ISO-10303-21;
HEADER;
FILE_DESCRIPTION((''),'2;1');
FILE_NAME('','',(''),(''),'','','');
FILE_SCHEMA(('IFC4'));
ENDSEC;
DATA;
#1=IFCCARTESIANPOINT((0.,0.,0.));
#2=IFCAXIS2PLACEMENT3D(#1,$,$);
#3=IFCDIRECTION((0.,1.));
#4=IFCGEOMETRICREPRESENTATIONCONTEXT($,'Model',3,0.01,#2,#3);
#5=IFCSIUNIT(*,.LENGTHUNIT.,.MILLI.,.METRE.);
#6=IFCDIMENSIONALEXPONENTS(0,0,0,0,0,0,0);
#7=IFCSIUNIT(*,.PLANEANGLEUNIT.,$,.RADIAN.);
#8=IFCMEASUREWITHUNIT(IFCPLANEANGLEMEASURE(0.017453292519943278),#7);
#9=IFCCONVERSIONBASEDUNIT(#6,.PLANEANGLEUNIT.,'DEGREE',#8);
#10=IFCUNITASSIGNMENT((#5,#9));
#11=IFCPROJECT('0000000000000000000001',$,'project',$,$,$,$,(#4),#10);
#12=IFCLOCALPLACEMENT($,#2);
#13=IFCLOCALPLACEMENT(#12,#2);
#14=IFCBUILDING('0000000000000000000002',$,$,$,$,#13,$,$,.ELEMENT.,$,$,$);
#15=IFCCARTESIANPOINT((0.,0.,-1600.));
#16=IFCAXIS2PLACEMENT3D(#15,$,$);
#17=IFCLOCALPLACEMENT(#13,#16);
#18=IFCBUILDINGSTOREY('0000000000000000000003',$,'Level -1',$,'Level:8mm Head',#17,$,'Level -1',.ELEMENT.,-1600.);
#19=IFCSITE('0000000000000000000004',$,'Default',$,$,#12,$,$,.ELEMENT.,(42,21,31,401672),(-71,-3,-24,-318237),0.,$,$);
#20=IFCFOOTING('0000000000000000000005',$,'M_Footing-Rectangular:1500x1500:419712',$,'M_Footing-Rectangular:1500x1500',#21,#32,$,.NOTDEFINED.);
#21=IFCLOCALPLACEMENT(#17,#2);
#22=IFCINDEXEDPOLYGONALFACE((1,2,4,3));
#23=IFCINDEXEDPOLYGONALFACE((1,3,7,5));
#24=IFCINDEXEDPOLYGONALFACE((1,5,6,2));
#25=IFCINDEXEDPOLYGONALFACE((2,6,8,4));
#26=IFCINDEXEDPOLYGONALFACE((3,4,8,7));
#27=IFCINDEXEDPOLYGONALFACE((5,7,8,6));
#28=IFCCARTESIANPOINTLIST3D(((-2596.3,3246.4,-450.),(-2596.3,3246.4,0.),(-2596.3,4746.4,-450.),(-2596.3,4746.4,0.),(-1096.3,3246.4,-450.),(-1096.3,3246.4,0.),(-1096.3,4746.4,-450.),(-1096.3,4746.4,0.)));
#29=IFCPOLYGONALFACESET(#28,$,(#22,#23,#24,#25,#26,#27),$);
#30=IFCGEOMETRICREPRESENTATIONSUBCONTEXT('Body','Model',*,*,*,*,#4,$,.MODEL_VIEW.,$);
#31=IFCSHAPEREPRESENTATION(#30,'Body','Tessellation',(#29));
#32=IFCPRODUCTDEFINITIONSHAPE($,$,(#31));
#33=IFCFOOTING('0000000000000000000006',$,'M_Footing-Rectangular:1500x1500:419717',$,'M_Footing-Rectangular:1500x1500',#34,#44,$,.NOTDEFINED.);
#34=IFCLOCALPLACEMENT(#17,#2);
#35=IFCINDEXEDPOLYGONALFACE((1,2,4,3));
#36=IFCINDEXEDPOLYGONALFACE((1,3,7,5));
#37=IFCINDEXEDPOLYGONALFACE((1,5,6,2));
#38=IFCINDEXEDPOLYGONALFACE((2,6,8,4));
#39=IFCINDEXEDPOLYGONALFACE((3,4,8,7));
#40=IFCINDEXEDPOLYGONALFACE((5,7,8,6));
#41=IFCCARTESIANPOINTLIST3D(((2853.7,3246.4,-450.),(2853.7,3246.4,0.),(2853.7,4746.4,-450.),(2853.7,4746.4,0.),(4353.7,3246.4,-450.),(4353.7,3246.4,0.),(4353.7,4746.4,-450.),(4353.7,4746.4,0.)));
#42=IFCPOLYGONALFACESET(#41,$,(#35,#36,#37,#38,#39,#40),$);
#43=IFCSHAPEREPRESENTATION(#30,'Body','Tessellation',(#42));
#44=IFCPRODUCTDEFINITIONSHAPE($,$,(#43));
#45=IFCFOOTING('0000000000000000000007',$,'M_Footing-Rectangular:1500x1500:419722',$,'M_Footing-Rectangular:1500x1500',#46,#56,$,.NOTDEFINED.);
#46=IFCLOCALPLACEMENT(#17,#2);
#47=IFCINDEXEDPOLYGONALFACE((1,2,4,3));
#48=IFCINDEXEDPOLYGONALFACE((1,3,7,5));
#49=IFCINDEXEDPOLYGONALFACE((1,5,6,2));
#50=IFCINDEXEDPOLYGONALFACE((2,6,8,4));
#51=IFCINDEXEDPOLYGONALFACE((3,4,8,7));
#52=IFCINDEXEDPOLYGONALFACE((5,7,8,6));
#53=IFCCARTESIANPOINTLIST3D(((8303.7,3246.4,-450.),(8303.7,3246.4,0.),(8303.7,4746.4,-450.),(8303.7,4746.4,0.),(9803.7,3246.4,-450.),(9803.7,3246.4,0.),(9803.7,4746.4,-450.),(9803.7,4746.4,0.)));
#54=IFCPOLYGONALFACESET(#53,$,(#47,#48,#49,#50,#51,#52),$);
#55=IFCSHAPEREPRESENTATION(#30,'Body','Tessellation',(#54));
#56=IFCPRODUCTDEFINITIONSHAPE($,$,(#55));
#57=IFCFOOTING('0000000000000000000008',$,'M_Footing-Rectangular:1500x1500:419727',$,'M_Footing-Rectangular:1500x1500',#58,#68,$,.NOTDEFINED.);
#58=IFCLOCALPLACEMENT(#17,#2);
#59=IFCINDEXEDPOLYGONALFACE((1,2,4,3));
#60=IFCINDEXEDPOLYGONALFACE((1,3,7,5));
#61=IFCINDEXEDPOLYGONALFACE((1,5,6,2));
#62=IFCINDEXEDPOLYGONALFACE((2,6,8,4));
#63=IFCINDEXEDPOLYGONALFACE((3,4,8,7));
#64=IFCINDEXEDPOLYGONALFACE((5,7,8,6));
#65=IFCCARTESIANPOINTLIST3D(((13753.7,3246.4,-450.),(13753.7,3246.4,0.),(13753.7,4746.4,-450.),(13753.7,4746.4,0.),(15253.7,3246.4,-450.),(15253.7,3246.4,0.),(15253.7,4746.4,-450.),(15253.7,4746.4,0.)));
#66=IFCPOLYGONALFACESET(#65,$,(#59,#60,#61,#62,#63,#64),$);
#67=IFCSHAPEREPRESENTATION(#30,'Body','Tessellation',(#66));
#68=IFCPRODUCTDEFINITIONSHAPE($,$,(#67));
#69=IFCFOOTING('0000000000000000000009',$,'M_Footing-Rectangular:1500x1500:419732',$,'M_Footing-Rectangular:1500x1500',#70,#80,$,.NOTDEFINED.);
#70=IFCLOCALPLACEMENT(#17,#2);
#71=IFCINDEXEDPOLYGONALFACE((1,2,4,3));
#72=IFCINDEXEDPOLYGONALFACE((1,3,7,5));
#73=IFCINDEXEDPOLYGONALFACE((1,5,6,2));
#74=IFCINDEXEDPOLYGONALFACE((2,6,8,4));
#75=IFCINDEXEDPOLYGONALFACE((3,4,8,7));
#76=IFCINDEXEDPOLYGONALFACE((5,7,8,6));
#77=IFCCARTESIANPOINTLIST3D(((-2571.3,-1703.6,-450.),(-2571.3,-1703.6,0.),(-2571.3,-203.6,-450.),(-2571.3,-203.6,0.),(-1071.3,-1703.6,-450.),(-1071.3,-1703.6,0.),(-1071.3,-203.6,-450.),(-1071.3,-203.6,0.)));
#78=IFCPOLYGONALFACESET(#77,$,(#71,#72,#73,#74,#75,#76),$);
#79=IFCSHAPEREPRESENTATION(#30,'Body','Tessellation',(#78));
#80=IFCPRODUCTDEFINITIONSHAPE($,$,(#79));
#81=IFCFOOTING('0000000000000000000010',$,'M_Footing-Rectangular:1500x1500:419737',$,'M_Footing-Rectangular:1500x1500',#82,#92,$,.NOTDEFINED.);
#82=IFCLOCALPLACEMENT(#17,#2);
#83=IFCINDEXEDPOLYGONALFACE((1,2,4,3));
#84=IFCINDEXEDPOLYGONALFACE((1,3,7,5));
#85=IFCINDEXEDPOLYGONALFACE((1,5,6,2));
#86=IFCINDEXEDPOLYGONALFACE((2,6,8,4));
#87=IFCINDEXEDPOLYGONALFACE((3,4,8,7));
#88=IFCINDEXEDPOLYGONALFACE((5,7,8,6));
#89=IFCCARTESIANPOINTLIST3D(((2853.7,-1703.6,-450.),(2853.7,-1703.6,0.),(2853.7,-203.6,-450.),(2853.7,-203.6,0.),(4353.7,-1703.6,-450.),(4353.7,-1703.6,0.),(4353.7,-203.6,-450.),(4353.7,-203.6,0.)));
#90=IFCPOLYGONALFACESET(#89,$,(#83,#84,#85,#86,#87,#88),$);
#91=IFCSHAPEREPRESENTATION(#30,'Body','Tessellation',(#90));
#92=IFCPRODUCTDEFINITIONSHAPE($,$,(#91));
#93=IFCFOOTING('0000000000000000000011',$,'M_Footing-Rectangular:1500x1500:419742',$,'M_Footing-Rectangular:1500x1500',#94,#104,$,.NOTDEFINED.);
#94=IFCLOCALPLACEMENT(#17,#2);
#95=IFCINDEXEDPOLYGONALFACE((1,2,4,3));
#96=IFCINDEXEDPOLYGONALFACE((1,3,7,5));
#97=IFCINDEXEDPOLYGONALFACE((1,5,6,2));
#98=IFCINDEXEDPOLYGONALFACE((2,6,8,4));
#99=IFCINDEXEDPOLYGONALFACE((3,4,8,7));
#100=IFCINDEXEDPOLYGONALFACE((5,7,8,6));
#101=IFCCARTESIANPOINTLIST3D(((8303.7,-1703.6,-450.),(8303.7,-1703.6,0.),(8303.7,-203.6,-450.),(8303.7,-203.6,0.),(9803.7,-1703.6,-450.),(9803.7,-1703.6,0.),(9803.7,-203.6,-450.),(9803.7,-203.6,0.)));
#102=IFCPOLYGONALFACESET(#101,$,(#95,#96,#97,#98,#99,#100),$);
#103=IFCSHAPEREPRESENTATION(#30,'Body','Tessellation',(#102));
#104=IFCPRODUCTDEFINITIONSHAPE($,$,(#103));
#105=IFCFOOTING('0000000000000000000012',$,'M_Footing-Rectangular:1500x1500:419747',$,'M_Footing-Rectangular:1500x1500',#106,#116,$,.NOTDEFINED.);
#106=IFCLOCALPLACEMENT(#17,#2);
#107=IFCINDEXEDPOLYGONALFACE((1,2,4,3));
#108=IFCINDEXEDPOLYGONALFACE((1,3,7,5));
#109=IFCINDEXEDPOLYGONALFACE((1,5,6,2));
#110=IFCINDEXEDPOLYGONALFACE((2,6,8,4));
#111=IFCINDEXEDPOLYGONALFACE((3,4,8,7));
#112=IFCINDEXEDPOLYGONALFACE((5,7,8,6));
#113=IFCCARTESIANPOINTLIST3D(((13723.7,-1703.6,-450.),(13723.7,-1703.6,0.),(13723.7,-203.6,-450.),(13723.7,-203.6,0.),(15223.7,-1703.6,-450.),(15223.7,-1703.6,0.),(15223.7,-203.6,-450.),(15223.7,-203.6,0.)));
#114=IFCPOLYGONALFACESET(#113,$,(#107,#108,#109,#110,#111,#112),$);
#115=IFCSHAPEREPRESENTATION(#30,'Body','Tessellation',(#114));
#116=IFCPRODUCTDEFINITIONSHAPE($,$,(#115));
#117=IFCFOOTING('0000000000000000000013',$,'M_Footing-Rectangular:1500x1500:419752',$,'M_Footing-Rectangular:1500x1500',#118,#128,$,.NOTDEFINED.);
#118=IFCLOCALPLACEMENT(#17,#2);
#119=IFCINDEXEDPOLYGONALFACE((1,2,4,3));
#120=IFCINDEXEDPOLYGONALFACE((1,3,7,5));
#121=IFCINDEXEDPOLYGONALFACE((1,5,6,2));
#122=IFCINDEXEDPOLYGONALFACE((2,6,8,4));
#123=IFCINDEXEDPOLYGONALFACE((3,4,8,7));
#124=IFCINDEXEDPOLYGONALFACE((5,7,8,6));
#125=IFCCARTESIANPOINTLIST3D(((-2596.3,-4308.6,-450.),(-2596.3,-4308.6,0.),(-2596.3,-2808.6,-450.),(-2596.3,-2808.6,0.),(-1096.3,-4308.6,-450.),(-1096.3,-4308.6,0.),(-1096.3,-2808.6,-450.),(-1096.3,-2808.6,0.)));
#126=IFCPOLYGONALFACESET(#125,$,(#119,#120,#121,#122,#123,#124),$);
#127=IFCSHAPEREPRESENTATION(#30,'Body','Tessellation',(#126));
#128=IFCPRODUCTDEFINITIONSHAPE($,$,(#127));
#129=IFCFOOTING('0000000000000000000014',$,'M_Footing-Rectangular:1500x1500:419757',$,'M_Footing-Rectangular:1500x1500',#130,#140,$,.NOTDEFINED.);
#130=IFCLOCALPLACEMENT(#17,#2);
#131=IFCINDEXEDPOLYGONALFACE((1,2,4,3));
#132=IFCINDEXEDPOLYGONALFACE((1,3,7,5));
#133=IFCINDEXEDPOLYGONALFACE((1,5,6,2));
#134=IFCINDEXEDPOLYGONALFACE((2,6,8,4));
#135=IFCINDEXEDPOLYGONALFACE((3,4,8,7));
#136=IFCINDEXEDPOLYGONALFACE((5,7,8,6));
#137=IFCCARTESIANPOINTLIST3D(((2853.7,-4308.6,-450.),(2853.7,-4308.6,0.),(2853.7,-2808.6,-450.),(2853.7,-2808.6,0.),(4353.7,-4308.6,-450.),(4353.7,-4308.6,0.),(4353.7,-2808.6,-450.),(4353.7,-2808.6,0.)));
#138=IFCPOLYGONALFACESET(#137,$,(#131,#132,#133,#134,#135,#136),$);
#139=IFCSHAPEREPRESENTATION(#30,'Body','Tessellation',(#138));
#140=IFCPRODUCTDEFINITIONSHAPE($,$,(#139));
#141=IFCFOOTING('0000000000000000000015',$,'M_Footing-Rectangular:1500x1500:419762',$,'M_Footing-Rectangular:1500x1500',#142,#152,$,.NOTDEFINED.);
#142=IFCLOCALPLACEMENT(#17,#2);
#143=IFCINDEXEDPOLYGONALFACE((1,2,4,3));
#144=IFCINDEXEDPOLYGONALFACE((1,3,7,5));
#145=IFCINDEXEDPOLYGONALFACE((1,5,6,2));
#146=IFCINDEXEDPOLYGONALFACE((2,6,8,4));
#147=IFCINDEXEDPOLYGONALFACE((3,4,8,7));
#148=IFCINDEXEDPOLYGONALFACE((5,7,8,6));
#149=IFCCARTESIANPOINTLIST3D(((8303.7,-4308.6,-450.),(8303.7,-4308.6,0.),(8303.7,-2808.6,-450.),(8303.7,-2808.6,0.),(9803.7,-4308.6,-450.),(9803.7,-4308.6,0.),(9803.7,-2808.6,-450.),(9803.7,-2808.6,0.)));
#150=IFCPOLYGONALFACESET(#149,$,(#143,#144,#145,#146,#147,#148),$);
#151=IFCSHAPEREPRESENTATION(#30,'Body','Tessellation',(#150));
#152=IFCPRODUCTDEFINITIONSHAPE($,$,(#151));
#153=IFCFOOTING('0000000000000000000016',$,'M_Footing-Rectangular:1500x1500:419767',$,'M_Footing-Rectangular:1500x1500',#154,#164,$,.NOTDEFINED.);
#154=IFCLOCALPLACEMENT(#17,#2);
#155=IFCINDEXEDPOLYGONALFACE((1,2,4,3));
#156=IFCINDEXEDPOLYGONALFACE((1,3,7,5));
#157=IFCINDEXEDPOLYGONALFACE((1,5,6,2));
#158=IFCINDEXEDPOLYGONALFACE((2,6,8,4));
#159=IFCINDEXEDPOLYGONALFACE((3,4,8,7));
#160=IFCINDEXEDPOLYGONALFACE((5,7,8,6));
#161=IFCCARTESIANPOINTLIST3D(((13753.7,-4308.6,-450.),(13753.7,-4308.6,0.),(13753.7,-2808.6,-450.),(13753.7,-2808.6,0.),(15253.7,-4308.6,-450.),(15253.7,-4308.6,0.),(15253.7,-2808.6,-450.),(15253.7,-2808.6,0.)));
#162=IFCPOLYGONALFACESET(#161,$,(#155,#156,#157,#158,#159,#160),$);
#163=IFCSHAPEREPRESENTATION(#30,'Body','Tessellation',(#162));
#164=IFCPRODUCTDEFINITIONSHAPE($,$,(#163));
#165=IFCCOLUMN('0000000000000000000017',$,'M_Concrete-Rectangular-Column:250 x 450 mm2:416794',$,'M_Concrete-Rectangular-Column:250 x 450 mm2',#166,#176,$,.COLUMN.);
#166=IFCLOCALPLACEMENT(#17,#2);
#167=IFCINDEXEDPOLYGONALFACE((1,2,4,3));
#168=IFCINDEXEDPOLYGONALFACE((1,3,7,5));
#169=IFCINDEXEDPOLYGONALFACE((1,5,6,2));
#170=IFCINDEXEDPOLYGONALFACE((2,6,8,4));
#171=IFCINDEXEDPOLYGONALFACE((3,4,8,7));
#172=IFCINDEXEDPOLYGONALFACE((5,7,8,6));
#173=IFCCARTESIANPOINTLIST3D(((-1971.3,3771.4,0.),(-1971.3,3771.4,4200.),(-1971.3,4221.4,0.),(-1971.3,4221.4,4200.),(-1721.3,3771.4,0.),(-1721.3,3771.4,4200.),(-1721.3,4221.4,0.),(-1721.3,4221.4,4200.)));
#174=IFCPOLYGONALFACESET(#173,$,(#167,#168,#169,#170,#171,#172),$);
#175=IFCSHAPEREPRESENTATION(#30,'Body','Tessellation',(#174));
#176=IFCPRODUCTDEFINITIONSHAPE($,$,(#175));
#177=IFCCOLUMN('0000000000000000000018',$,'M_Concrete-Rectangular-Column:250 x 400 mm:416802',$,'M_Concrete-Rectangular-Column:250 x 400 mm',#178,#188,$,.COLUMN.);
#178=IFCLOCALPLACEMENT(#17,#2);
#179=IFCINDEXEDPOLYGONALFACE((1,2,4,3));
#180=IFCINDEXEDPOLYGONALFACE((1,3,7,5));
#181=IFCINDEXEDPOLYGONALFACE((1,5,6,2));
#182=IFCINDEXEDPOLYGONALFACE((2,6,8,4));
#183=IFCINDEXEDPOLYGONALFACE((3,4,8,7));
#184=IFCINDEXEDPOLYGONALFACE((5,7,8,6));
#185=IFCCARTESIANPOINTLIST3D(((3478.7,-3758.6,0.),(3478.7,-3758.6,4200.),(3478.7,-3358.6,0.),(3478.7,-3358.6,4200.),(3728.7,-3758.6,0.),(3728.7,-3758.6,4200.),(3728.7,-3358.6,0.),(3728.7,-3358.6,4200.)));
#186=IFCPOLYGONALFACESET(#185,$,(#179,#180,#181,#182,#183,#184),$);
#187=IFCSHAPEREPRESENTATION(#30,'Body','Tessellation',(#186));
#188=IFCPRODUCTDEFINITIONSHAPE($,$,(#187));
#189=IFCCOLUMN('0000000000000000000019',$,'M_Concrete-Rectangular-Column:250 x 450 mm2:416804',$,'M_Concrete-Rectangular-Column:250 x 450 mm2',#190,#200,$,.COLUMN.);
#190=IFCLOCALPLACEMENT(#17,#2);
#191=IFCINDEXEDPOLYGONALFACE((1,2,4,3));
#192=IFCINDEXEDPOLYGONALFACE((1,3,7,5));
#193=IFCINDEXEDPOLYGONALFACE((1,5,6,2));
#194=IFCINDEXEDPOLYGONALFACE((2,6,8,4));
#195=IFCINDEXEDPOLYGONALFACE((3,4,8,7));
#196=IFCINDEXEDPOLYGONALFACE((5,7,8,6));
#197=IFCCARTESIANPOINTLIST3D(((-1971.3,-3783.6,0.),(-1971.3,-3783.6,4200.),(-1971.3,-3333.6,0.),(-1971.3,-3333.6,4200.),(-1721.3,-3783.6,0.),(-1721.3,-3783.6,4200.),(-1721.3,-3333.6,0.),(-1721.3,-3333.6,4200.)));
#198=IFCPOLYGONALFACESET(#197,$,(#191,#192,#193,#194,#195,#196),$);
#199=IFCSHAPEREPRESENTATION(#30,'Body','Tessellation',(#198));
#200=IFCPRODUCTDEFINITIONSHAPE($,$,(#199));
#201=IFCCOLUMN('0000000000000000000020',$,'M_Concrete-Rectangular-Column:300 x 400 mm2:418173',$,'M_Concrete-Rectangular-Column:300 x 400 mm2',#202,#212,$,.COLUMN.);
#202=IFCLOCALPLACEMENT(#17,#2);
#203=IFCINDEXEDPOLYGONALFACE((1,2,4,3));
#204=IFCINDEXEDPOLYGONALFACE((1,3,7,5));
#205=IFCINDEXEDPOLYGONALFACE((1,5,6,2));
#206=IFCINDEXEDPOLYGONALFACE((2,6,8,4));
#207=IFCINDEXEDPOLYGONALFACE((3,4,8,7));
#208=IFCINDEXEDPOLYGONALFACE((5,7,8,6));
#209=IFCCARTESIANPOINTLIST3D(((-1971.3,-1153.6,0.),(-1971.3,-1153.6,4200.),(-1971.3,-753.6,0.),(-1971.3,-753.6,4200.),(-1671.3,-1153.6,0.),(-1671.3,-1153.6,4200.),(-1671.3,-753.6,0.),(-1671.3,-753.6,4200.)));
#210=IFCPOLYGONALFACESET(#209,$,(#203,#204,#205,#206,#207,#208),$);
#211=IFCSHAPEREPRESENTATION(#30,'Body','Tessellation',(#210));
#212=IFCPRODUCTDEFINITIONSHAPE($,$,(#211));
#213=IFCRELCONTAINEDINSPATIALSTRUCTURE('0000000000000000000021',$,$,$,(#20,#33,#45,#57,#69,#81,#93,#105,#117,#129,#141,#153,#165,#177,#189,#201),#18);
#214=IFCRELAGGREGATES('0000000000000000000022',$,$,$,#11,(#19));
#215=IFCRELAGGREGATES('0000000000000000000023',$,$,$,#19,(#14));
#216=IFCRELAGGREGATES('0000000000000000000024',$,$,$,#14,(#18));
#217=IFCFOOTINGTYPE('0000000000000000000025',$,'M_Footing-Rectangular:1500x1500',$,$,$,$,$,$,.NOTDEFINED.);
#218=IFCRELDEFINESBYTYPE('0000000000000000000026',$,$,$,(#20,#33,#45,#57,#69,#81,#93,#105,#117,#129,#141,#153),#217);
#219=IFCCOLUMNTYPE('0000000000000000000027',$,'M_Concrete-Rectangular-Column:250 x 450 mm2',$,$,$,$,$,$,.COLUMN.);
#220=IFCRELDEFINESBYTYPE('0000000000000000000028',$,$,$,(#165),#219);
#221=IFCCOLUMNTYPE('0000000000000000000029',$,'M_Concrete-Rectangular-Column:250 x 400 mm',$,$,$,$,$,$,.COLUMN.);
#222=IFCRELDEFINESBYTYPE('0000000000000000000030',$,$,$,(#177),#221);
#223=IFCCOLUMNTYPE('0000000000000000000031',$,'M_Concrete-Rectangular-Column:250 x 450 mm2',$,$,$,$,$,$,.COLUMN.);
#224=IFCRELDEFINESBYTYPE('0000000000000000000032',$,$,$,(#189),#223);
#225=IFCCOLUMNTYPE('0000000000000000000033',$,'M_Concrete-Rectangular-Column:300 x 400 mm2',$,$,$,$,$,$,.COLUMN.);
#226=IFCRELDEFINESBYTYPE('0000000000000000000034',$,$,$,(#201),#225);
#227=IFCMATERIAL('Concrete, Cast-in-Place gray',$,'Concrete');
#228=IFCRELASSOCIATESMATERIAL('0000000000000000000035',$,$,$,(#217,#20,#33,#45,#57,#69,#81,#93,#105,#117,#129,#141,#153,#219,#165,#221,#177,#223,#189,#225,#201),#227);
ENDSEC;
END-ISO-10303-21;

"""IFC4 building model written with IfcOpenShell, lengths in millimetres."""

from ifc_helpers import new_model, entity, si_unit, converted_unit, direction, frame, origin, place, context, subcontext, project, spatial, indexed_curve, outline, extrude, source, transform, mapped, material, type_object, type_shapes, element, save


model = new_model("IFC4")

# Units and contexts
model_context = context("Model", 3, precision=0.01, world=origin(), true_north=direction((0.0, 1.0)))
body_context = subcontext(model_context, "Body", "Model", "MODEL_VIEW")
ifc_project = project(units=[si_unit("LENGTHUNIT", "METRE", prefix="MILLI"), converted_unit("PLANEANGLEUNIT", "DEGREE", entity("IfcPlaneAngleMeasure", 0.017453292519943278), si_unit("PLANEANGLEUNIT", "RADIAN"), dimensions=[0, 0, 0, 0, 0, 0, 0])], contexts=[model_context])

# Site, building, storey
site_placement = place(None, origin())
site = spatial("IfcSite", under=ifc_project, at=site_placement, Name="Default", CompositionType="ELEMENT", RefLatitude=(42, 21, 31, 401672), RefLongitude=(-71, -3, -24, -318237), RefElevation=0.0)
building_placement = place(site_placement, origin())
building = spatial("IfcBuilding", under=site, at=building_placement, CompositionType="ELEMENT")
storey_placement = place(building_placement, frame((0.0, 0.0, -1600.0)))
storey = spatial("IfcBuildingStorey", under=building, at=storey_placement, Name="Level -1", ObjectType="Level:8mm Head", LongName="Level -1", CompositionType="ELEMENT", Elevation=-1600.0)

# Footings
ifc_material = material(Name="Concrete, Cast-in-Place gray", Category="Concrete")
footing_type = type_object("IfcFootingType", Name="M_Footing-Rectangular:1500x1500", PredefinedType="NOTDEFINED", material=ifc_material)
shared_shape_1 = source(origin(), body_context, "Body", "SweptSolid", [
    extrude(outline(indexed_curve([(-750.0, -750.0), (750.0, -750.0), (750.0, 750.0), (-750.0, 750.0), (-750.0, -750.0)], self_intersect=False)), frame((0.0, 0.0, -450.0), z_axis=(0.0, 0.0, 1.0), x_axis=(-1.0, 0.0, 0.0)), (0.0, 0.0, 1.0), 450.0),
])
type_shapes(footing_type, [shared_shape_1])
for number, where, name in (
    (1, (-1846.3, 3996.4, 0.0), "M_Footing-Rectangular:1500x1500:419712"),
    (2, (3603.7, 3996.4, 0.0), "M_Footing-Rectangular:1500x1500:419717"),
    (3, (9053.7, 3996.4, 0.0), "M_Footing-Rectangular:1500x1500:419722"),
    (4, (14503.7, 3996.4, 0.0), "M_Footing-Rectangular:1500x1500:419727"),
    (5, (-1821.3, -953.6, 0.0), "M_Footing-Rectangular:1500x1500:419732"),
    (6, (3603.7, -953.6, 0.0), "M_Footing-Rectangular:1500x1500:419737"),
    (7, (9053.7, -953.6, 0.0), "M_Footing-Rectangular:1500x1500:419742"),
    (8, (14473.7, -953.6, 0.0), "M_Footing-Rectangular:1500x1500:419747"),
    (9, (-1846.3, -3558.6, 0.0), "M_Footing-Rectangular:1500x1500:419752"),
    (10, (3603.7, -3558.6, 0.0), "M_Footing-Rectangular:1500x1500:419757"),
    (11, (9053.7, -3558.6, 0.0), "M_Footing-Rectangular:1500x1500:419762"),
    (12, (14503.7, -3558.6, 0.0), "M_Footing-Rectangular:1500x1500:419767"),
):
    element("IfcFooting", number, at=place(storey_placement, frame(where)), inside=storey, type_object=footing_type, material=ifc_material, Name=name, ObjectType="M_Footing-Rectangular:1500x1500", PredefinedType="NOTDEFINED", context=body_context, shape_type="MappedRepresentation", body=[
        mapped(shared_shape_1, transform((0.0, 0.0, 0.0), scale=1.0)),
    ])

# Columns
column_type_1 = type_object("IfcColumnType", Name="M_Concrete-Rectangular-Column:250 x 450 mm2", PredefinedType="COLUMN", material=ifc_material)
shared_shape_2 = source(origin(), body_context, "Body", "SweptSolid", [
    extrude(outline(indexed_curve([(-2100.0, -225.0), (2100.0, -225.0), (2100.0, 225.0), (-2100.0, 225.0), (-2100.0, -225.0)], self_intersect=False)), frame((-1971.3, 3996.4, 500.0), z_axis=(1.0, 0.0, 0.0), x_axis=(0.0, 0.0, 1.0)), (0.0, 0.0, 1.0), 250.0),
])
type_shapes(column_type_1, [shared_shape_2])
column_1_placement = place(storey_placement, frame((0.0, 0.0, 1600.0)))
element("IfcColumn", 13, at=column_1_placement, inside=storey, type_object=column_type_1, material=ifc_material, Name="M_Concrete-Rectangular-Column:250 x 450 mm2:416794", ObjectType="M_Concrete-Rectangular-Column:250 x 450 mm2", PredefinedType="COLUMN", context=body_context, shape_type="MappedRepresentation", body=[
    mapped(shared_shape_2, transform((0.0, 0.0, 0.0), scale=1.0)),
])
column_type_2 = type_object("IfcColumnType", Name="M_Concrete-Rectangular-Column:250 x 400 mm", PredefinedType="COLUMN", material=ifc_material)
shared_shape_3 = source(origin(), body_context, "Body", "SweptSolid", [
    extrude(outline(indexed_curve([(-2100.0, -200.0), (2100.0, -200.0), (2100.0, 200.0), (-2100.0, 200.0), (-2100.0, -200.0)], self_intersect=False)), frame((3478.7, -3558.6, 500.0), z_axis=(1.0, 0.0, 0.0), x_axis=(0.0, 0.0, 1.0)), (0.0, 0.0, 1.0), 250.0),
])
type_shapes(column_type_2, [shared_shape_3])
column_2_placement = place(storey_placement, frame((0.0, 0.0, 1600.0)))
element("IfcColumn", 14, at=column_2_placement, inside=storey, type_object=column_type_2, material=ifc_material, Name="M_Concrete-Rectangular-Column:250 x 400 mm:416802", ObjectType="M_Concrete-Rectangular-Column:250 x 400 mm", PredefinedType="COLUMN", context=body_context, shape_type="MappedRepresentation", body=[
    mapped(shared_shape_3, transform((0.0, 0.0, 0.0), scale=1.0)),
])
column_type_3 = type_object("IfcColumnType", Name="M_Concrete-Rectangular-Column:250 x 450 mm2", PredefinedType="COLUMN", material=ifc_material)
shared_shape_4 = source(origin(), body_context, "Body", "SweptSolid", [
    extrude(outline(indexed_curve([(-2100.0, -225.0), (2100.0, -225.0), (2100.0, 225.0), (-2100.0, 225.0), (-2100.0, -225.0)], self_intersect=False)), frame((-1971.3, -3558.6, 500.0), z_axis=(1.0, 0.0, 0.0), x_axis=(0.0, 0.0, 1.0)), (0.0, 0.0, 1.0), 250.0),
])
type_shapes(column_type_3, [shared_shape_4])
column_3_placement = place(storey_placement, frame((0.0, 0.0, 1600.0)))
element("IfcColumn", 15, at=column_3_placement, inside=storey, type_object=column_type_3, material=ifc_material, Name="M_Concrete-Rectangular-Column:250 x 450 mm2:416804", ObjectType="M_Concrete-Rectangular-Column:250 x 450 mm2", PredefinedType="COLUMN", context=body_context, shape_type="MappedRepresentation", body=[
    mapped(shared_shape_4, transform((0.0, 0.0, 0.0), scale=1.0)),
])
column_type_4 = type_object("IfcColumnType", Name="M_Concrete-Rectangular-Column:300 x 400 mm2", PredefinedType="COLUMN", material=ifc_material)
shared_shape_5 = source(origin(), body_context, "Body", "SweptSolid", [
    extrude(outline(indexed_curve([(-2100.0, -200.0), (2100.0, -200.0), (2100.0, 200.0), (-2100.0, 200.0), (-2100.0, -200.0)], self_intersect=False)), frame((-1971.3, -953.6, 500.0), z_axis=(1.0, 0.0, 0.0), x_axis=(0.0, 0.0, 1.0)), (0.0, 0.0, 1.0), 300.0),
])
type_shapes(column_type_4, [shared_shape_5])
column_4_placement = place(storey_placement, frame((0.0, 0.0, 1600.0)))
element("IfcColumn", 16, at=column_4_placement, inside=storey, type_object=column_type_4, material=ifc_material, Name="M_Concrete-Rectangular-Column:300 x 400 mm2:418173", ObjectType="M_Concrete-Rectangular-Column:300 x 400 mm2", PredefinedType="COLUMN", context=body_context, shape_type="MappedRepresentation", body=[
    mapped(shared_shape_5, transform((0.0, 0.0, 0.0), scale=1.0)),
])

save(model, "model.ifc")
